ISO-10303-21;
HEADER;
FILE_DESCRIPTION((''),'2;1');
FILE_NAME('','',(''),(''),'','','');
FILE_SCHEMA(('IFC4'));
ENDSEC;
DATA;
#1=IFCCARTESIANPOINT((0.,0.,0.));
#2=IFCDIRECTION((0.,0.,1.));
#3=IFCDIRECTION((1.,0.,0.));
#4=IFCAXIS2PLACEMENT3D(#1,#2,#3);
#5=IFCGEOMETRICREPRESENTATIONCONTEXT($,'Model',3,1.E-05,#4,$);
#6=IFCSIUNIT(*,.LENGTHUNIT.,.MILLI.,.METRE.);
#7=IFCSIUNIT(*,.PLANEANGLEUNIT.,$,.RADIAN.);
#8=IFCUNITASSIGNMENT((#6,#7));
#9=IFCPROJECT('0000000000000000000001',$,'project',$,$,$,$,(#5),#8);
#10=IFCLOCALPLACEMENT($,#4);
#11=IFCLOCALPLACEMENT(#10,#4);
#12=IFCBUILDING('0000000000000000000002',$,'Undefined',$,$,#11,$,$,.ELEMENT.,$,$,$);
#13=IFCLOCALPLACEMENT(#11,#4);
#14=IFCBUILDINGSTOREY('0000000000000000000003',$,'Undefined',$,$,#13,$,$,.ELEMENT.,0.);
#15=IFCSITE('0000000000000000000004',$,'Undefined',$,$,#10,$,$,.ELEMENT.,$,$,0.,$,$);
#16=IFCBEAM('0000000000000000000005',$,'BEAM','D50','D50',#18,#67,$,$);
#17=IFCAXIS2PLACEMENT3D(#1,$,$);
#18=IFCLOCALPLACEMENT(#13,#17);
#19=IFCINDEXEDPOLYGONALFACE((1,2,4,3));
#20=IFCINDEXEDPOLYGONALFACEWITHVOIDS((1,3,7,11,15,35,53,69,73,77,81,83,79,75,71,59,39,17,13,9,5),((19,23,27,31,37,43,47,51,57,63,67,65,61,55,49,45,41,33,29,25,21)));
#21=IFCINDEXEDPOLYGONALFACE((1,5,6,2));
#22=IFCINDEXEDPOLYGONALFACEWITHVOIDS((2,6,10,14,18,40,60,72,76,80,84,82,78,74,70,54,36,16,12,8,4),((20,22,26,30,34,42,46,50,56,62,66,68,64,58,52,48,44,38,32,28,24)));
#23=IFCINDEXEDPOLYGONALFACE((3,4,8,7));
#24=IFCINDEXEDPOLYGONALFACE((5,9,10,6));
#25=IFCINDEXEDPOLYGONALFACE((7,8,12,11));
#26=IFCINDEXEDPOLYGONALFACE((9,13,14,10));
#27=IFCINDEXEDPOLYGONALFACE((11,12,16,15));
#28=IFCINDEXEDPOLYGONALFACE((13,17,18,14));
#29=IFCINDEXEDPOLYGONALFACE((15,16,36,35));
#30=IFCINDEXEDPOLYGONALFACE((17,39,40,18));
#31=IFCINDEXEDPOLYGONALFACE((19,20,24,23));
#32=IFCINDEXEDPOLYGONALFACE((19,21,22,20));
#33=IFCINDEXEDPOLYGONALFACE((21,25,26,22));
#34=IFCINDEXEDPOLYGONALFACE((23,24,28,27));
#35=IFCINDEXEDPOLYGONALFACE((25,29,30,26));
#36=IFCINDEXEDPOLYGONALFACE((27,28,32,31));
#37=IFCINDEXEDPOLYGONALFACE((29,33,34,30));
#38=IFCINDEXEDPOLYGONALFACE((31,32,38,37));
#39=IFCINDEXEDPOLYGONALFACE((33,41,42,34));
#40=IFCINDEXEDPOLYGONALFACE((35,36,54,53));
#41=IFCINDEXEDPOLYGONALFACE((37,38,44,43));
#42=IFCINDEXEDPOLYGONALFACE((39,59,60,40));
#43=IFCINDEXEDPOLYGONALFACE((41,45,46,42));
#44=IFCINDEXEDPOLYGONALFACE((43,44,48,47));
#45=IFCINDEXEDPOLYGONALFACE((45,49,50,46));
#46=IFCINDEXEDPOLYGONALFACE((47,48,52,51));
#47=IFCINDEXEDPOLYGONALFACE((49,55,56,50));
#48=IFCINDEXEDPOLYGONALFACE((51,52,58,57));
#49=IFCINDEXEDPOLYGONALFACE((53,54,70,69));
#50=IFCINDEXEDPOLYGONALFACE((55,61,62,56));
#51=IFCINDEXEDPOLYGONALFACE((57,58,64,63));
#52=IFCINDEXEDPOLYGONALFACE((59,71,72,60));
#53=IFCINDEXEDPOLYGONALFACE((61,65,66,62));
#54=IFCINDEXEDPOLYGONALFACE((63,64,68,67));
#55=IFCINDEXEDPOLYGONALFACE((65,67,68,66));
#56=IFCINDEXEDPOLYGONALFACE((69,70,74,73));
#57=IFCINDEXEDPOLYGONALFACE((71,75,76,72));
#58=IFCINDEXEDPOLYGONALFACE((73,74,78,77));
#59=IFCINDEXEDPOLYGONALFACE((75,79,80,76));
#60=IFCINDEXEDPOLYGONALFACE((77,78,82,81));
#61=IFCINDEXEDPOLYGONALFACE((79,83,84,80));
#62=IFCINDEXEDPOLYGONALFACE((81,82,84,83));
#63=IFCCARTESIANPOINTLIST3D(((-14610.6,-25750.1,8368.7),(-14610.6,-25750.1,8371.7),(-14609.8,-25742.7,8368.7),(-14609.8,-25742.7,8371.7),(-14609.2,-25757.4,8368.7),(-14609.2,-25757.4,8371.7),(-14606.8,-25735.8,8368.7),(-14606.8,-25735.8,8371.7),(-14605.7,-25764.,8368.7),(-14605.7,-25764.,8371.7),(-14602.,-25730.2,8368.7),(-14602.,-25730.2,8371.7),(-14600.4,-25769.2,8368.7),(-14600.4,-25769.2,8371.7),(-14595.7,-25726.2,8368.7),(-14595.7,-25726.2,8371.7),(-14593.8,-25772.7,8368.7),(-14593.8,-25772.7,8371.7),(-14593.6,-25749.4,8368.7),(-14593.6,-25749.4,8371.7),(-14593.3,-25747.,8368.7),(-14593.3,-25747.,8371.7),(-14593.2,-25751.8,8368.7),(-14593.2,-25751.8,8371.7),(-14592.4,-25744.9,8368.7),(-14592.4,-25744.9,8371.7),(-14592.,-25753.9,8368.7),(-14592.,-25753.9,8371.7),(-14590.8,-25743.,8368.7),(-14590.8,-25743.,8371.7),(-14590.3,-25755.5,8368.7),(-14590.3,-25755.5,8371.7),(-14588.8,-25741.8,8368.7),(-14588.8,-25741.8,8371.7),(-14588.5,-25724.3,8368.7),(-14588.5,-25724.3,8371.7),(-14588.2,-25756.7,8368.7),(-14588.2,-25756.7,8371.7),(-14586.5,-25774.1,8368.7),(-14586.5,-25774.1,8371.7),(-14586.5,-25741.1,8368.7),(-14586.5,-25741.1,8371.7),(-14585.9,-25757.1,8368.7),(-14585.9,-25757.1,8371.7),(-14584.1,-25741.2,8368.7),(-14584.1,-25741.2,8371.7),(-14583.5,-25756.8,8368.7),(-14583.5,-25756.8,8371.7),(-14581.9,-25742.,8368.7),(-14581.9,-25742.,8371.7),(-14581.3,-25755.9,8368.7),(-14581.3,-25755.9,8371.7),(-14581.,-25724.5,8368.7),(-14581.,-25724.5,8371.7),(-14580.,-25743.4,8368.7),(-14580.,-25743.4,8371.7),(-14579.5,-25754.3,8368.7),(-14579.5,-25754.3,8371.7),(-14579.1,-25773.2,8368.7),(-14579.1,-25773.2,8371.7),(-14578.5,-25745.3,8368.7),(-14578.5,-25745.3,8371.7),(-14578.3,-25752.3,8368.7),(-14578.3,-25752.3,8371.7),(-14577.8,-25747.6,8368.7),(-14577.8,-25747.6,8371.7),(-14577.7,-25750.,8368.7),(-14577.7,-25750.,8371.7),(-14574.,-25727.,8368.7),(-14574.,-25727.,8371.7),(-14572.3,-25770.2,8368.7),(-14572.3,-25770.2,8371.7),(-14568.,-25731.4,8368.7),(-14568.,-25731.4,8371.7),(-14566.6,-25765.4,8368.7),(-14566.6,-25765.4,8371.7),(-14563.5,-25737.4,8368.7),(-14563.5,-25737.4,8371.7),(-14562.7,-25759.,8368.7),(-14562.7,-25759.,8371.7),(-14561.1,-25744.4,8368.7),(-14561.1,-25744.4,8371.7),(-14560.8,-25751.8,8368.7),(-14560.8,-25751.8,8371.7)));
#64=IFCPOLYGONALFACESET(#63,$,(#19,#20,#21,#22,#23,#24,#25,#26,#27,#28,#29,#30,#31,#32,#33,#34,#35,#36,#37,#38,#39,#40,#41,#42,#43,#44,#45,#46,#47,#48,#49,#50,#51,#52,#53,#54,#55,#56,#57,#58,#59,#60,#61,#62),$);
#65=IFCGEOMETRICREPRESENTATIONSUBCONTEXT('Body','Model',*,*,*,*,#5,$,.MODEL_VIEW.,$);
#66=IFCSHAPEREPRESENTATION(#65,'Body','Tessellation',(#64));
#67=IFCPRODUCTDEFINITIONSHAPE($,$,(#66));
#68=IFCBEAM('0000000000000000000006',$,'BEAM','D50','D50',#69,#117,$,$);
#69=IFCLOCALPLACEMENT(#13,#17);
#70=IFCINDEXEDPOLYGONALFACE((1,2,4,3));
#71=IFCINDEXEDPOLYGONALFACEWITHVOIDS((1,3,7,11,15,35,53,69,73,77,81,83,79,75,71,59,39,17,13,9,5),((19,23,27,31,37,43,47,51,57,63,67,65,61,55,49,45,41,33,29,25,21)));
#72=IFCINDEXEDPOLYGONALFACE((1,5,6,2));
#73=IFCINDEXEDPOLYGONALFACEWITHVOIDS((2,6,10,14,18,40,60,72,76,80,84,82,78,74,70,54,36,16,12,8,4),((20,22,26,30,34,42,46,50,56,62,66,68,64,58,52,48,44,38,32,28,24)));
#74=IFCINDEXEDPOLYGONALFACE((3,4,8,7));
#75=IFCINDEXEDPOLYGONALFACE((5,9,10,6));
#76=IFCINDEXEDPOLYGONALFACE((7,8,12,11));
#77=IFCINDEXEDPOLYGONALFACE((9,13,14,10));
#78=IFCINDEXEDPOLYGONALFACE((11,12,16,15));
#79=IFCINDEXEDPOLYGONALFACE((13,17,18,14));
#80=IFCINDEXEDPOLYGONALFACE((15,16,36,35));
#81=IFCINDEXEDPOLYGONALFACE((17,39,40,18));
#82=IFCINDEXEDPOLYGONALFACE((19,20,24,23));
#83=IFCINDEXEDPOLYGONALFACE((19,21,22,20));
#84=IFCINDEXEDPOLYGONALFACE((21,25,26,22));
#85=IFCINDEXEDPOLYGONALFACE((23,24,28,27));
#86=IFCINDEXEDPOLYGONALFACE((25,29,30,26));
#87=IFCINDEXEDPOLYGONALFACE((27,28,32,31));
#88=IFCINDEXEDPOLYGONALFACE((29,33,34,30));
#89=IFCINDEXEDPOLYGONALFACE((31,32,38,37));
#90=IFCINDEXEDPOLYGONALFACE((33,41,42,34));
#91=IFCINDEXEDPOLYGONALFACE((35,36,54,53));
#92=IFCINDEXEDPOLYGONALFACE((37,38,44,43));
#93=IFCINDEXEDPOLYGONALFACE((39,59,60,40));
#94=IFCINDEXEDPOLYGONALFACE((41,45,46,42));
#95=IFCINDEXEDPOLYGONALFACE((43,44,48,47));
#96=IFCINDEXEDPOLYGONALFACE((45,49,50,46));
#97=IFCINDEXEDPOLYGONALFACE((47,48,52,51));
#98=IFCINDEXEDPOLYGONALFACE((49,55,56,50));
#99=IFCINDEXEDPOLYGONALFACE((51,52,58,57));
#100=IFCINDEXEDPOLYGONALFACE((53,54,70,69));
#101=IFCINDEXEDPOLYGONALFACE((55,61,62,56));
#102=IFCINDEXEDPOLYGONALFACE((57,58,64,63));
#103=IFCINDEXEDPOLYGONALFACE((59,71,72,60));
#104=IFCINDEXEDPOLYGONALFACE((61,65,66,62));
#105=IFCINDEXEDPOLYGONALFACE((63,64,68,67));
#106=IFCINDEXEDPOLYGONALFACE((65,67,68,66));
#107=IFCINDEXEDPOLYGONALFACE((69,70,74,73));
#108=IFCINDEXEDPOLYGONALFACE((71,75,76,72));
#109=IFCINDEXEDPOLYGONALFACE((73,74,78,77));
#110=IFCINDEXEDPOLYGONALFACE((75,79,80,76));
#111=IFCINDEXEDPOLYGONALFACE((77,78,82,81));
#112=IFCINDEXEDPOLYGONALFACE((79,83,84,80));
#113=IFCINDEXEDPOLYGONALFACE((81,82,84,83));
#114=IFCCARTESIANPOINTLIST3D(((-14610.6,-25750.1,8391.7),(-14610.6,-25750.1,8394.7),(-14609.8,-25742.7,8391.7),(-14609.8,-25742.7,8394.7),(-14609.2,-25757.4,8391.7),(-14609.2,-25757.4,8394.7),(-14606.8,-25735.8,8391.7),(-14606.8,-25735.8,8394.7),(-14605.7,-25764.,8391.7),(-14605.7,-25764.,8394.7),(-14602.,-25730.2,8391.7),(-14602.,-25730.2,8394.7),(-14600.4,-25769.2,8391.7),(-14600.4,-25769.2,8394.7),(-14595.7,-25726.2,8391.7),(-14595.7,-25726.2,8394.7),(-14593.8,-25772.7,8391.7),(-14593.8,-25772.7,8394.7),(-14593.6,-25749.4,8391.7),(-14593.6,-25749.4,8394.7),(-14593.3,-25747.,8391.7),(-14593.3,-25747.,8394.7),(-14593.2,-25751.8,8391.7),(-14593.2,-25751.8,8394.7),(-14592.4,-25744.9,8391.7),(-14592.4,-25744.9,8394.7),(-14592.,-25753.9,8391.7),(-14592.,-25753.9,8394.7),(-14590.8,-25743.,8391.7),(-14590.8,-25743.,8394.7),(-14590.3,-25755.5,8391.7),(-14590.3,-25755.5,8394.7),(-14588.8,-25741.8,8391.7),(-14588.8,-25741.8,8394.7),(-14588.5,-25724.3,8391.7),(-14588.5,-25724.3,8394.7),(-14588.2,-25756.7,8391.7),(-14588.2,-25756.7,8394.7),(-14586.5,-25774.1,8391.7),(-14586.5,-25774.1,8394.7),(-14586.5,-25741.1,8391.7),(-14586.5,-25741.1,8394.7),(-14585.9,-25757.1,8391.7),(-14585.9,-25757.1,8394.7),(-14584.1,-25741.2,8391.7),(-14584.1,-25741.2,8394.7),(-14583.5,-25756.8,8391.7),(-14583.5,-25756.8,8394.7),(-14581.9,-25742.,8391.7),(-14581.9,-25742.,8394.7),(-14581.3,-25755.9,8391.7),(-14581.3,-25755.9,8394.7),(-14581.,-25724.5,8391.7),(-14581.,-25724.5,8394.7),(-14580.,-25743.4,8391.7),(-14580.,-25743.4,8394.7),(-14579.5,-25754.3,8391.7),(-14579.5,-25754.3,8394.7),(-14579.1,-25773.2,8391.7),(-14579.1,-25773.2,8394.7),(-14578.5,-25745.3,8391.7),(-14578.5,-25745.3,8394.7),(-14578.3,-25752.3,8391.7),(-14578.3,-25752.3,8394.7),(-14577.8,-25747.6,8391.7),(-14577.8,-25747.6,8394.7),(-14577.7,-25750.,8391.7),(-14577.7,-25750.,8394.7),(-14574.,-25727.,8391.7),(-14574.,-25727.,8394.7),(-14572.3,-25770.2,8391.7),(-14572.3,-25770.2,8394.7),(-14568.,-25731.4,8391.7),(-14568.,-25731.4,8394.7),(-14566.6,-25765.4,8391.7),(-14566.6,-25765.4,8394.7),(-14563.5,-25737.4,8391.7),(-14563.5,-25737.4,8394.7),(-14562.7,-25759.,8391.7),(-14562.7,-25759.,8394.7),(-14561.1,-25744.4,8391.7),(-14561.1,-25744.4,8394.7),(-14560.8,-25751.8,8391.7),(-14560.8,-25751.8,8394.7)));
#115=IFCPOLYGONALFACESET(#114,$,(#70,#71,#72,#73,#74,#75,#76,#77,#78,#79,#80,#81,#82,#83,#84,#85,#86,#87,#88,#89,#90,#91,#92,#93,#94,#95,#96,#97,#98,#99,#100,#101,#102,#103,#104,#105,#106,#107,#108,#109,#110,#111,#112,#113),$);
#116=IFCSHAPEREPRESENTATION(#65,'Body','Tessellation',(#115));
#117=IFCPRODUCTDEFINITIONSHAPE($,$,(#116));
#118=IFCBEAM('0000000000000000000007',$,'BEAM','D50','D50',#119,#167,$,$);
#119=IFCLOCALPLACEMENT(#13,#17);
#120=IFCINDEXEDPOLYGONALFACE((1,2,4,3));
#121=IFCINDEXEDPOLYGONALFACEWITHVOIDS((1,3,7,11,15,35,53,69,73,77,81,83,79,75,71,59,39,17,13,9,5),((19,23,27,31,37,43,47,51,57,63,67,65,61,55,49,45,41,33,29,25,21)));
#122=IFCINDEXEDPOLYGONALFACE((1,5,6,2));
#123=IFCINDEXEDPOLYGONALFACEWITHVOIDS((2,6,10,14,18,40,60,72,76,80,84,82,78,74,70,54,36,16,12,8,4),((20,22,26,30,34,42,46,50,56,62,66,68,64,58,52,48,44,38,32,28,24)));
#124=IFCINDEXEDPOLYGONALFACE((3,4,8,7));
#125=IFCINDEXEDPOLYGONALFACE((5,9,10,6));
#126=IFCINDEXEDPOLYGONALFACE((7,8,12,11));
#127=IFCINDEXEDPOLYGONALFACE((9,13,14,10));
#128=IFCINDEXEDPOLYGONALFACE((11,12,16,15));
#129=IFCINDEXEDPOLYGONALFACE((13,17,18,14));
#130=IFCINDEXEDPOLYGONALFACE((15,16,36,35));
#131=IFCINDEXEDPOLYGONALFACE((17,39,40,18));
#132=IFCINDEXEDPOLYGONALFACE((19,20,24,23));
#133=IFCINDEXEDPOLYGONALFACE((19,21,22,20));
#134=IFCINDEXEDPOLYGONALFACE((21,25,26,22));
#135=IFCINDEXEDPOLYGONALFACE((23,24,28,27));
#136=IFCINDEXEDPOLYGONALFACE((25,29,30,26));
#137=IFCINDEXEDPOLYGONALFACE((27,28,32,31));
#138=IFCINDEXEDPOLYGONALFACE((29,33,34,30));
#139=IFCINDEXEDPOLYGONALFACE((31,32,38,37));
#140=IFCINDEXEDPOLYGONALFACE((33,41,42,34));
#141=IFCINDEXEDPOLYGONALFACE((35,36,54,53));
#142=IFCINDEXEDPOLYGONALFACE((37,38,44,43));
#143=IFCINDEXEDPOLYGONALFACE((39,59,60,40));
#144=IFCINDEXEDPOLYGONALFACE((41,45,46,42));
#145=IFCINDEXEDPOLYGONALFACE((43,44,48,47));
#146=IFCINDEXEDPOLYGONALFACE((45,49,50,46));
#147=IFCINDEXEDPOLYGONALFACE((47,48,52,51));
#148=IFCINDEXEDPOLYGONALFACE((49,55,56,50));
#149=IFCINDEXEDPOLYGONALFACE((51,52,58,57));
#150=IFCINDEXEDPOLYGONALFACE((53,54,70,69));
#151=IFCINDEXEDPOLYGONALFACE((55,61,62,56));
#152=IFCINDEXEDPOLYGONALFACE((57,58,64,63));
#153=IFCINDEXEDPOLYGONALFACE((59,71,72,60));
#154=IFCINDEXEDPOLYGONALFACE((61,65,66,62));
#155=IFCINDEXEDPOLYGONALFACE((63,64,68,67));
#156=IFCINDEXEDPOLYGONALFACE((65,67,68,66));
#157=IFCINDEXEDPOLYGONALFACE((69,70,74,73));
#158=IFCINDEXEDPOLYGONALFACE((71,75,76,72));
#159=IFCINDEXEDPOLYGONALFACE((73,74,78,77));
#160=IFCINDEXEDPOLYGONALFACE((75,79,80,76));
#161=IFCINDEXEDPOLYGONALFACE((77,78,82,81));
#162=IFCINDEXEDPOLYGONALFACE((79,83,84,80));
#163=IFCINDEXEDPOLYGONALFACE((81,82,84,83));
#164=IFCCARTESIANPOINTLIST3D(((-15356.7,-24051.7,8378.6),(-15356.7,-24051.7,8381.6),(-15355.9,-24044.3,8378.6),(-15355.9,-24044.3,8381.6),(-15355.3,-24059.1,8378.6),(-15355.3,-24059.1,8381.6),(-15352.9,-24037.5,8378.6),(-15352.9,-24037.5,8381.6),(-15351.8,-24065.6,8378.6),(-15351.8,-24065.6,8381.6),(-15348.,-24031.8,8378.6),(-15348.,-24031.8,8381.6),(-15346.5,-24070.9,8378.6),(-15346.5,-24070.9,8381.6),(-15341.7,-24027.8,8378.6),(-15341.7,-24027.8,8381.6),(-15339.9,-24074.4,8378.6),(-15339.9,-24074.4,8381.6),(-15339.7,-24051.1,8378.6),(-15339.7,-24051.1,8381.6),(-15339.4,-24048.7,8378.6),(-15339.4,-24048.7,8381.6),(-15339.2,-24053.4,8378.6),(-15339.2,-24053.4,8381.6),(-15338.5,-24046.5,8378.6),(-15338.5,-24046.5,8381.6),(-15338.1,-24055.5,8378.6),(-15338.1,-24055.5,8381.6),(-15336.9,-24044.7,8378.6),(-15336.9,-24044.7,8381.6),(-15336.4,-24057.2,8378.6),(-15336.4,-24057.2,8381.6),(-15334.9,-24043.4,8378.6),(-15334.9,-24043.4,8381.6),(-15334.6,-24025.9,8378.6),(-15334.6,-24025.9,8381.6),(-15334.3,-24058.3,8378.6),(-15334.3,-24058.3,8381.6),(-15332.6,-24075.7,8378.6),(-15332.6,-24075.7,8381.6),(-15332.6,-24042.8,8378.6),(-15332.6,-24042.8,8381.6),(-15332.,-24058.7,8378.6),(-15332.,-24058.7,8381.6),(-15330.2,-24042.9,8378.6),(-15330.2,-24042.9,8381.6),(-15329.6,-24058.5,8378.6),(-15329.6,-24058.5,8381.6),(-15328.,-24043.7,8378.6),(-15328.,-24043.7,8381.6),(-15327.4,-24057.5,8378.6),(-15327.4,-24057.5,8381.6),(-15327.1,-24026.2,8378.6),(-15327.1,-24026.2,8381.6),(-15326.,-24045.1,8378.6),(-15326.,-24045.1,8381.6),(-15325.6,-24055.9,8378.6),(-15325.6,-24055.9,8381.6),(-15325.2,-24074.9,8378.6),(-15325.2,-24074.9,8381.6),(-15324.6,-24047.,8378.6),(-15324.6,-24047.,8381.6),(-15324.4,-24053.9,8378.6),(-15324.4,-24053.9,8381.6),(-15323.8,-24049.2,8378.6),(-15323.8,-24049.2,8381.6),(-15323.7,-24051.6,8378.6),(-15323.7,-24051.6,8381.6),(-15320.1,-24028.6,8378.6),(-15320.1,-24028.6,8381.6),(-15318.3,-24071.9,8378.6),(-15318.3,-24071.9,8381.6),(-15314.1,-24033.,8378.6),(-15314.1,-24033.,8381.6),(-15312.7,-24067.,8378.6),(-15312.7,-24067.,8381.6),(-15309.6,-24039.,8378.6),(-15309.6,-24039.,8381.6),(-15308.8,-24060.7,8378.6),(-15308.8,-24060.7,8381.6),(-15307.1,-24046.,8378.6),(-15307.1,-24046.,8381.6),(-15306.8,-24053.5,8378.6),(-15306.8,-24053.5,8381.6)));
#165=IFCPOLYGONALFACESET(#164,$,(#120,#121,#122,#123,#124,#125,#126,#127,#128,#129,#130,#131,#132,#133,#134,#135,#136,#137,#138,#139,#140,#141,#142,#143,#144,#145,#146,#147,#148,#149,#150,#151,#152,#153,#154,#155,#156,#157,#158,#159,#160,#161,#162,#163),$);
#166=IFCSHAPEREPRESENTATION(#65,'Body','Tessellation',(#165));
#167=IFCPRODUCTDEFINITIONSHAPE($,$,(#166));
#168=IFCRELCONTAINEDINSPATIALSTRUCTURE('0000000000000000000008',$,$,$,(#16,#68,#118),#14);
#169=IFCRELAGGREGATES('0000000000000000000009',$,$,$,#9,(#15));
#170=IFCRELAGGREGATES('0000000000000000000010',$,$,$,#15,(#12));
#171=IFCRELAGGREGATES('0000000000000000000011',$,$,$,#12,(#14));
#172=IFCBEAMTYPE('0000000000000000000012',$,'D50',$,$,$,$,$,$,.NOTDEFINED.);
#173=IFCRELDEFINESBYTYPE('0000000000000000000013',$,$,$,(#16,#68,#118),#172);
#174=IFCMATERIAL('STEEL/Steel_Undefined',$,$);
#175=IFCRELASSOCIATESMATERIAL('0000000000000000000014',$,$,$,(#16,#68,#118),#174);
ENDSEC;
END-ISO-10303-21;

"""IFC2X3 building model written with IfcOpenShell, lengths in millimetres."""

from ifc_helpers import new_model, si_unit, frame, origin_with_axes, origin_2d_with_axis, place, context, subcontext, project, spatial, circle, extrude, material, type_object, element, save


model = new_model("IFC2X3")

# Units and contexts
model_context = context("Model", 3, precision=1e-05, world=origin_with_axes())
body_context = subcontext(model_context, "Body", "Model", "MODEL_VIEW")
ifc_project = project(units=[si_unit("LENGTHUNIT", "METRE", prefix="MILLI"), si_unit("PLANEANGLEUNIT", "RADIAN")], contexts=[model_context])

# Site, building, storey
site_placement = place(None, origin_with_axes())
site = spatial("IfcSite", under=ifc_project, at=site_placement, Name="Undefined", CompositionType="ELEMENT", RefElevation=0.0)
building_placement = place(site_placement, origin_with_axes())
building = spatial("IfcBuilding", under=site, at=building_placement, Name="Undefined", CompositionType="ELEMENT")
storey_placement = place(building_placement, origin_with_axes())
storey = spatial("IfcBuildingStorey", under=building, at=storey_placement, Name="Undefined", CompositionType="ELEMENT", Elevation=0.0)

# Beams, openings
ifc_material = material(Name="STEEL/Steel_Undefined")
beam_type_1 = type_object("IfcBeamType", Name="D50", PredefinedType="NOTDEFINED")
beam_1_placement = place(storey_placement, frame((-14585.6, -25749.1, 8371.7), z_axis=(-0.915553, -0.402197, 0.0), x_axis=(0.0, 0.0, -1.0)))
beam_1 = element("IfcBeam", 1, at=beam_1_placement, inside=storey, type_object=beam_type_1, material=ifc_material, Name="BEAM", Description="D50", ObjectType="D50", context=body_context, shape_type="SweptSolid", body=[
    extrude(circle(Radius=25.0, at=origin_2d_with_axis()), frame((3.0, 0.0, 0.0), z_axis=(-1.0, 0.0, 0.0), x_axis=(0.0, -1.0, 0.0)), (0.0, 0.0, 1.0), 3.0),
])
opening_1_placement = place(storey_placement, frame((-14585.6, -25749.1, 8371.7), z_axis=(-0.915553, -0.402197, 0.0), x_axis=(0.0, 0.0, -1.0)))
element("IfcOpeningElement", 2, at=opening_1_placement, cuts=beam_1, ObjectType="Recess", context=body_context, shape_type="SweptSolid", body=[
    extrude(circle(Radius=8.0, at=origin_2d_with_axis()), frame((245.5, 0.0, 0.0), z_axis=(-1.0, 0.0, 0.0), x_axis=(0.0, -1.0, 0.0)), (0.0, 0.0, 1.0), 292.6),
])
beam_2_placement = place(storey_placement, frame((-14585.6, -25749.1, 8394.7), z_axis=(-0.915553, -0.402197, 0.0), x_axis=(0.0, 0.0, -1.0)))
beam_2 = element("IfcBeam", 3, at=beam_2_placement, inside=storey, type_object=beam_type_1, material=ifc_material, Name="BEAM", Description="D50", ObjectType="D50", context=body_context, shape_type="SweptSolid", body=[
    extrude(circle(Radius=25.0, at=origin_2d_with_axis()), frame((3.0, 0.0, 0.0), z_axis=(-1.0, 0.0, 0.0), x_axis=(0.0, -1.0, 0.0)), (0.0, 0.0, 1.0), 3.0),
])
opening_2_placement = place(storey_placement, frame((-14585.6, -25749.1, 8394.7), z_axis=(-0.915553, -0.402197, 0.0), x_axis=(0.0, 0.0, -1.0)))
element("IfcOpeningElement", 4, at=opening_2_placement, cuts=beam_2, ObjectType="Recess", context=body_context, shape_type="SweptSolid", body=[
    extrude(circle(Radius=8.0, at=origin_2d_with_axis()), frame((268.5, 0.0, 0.0), z_axis=(-1.0, 0.0, 0.0), x_axis=(0.0, -1.0, 0.0)), (0.0, 0.0, 1.0), 292.6),
])
beam_3_placement = place(storey_placement, frame((-15331.7, -24050.7, 8381.6), z_axis=(-0.915552, -0.4022, 0.0), x_axis=(0.0, 0.0, -1.0)))
beam_3 = element("IfcBeam", 5, at=beam_3_placement, inside=storey, type_object=beam_type_1, material=ifc_material, Name="BEAM", Description="D50", ObjectType="D50", context=body_context, shape_type="SweptSolid", body=[
    extrude(circle(Radius=25.0, at=origin_2d_with_axis()), frame((3.0, 0.0, 0.0), z_axis=(-1.0, 0.0, 0.0), x_axis=(0.0, -1.0, 0.0)), (0.0, 0.0, 1.0), 3.0),
])
opening_3_placement = place(storey_placement, frame((-15331.7, -24050.7, 8381.6), z_axis=(-0.915552, -0.4022, 0.0), x_axis=(0.0, 0.0, -1.0)))
element("IfcOpeningElement", 6, at=opening_3_placement, cuts=beam_3, ObjectType="Recess", context=body_context, shape_type="SweptSolid", body=[
    extrude(circle(Radius=8.0, at=origin_2d_with_axis()), frame((245.5, 0.0, 0.0), z_axis=(-1.0, 0.0, 0.0), x_axis=(0.0, -1.0, 0.0)), (0.0, 0.0, 1.0), 292.6),
])

save(model, "model.ifc")
